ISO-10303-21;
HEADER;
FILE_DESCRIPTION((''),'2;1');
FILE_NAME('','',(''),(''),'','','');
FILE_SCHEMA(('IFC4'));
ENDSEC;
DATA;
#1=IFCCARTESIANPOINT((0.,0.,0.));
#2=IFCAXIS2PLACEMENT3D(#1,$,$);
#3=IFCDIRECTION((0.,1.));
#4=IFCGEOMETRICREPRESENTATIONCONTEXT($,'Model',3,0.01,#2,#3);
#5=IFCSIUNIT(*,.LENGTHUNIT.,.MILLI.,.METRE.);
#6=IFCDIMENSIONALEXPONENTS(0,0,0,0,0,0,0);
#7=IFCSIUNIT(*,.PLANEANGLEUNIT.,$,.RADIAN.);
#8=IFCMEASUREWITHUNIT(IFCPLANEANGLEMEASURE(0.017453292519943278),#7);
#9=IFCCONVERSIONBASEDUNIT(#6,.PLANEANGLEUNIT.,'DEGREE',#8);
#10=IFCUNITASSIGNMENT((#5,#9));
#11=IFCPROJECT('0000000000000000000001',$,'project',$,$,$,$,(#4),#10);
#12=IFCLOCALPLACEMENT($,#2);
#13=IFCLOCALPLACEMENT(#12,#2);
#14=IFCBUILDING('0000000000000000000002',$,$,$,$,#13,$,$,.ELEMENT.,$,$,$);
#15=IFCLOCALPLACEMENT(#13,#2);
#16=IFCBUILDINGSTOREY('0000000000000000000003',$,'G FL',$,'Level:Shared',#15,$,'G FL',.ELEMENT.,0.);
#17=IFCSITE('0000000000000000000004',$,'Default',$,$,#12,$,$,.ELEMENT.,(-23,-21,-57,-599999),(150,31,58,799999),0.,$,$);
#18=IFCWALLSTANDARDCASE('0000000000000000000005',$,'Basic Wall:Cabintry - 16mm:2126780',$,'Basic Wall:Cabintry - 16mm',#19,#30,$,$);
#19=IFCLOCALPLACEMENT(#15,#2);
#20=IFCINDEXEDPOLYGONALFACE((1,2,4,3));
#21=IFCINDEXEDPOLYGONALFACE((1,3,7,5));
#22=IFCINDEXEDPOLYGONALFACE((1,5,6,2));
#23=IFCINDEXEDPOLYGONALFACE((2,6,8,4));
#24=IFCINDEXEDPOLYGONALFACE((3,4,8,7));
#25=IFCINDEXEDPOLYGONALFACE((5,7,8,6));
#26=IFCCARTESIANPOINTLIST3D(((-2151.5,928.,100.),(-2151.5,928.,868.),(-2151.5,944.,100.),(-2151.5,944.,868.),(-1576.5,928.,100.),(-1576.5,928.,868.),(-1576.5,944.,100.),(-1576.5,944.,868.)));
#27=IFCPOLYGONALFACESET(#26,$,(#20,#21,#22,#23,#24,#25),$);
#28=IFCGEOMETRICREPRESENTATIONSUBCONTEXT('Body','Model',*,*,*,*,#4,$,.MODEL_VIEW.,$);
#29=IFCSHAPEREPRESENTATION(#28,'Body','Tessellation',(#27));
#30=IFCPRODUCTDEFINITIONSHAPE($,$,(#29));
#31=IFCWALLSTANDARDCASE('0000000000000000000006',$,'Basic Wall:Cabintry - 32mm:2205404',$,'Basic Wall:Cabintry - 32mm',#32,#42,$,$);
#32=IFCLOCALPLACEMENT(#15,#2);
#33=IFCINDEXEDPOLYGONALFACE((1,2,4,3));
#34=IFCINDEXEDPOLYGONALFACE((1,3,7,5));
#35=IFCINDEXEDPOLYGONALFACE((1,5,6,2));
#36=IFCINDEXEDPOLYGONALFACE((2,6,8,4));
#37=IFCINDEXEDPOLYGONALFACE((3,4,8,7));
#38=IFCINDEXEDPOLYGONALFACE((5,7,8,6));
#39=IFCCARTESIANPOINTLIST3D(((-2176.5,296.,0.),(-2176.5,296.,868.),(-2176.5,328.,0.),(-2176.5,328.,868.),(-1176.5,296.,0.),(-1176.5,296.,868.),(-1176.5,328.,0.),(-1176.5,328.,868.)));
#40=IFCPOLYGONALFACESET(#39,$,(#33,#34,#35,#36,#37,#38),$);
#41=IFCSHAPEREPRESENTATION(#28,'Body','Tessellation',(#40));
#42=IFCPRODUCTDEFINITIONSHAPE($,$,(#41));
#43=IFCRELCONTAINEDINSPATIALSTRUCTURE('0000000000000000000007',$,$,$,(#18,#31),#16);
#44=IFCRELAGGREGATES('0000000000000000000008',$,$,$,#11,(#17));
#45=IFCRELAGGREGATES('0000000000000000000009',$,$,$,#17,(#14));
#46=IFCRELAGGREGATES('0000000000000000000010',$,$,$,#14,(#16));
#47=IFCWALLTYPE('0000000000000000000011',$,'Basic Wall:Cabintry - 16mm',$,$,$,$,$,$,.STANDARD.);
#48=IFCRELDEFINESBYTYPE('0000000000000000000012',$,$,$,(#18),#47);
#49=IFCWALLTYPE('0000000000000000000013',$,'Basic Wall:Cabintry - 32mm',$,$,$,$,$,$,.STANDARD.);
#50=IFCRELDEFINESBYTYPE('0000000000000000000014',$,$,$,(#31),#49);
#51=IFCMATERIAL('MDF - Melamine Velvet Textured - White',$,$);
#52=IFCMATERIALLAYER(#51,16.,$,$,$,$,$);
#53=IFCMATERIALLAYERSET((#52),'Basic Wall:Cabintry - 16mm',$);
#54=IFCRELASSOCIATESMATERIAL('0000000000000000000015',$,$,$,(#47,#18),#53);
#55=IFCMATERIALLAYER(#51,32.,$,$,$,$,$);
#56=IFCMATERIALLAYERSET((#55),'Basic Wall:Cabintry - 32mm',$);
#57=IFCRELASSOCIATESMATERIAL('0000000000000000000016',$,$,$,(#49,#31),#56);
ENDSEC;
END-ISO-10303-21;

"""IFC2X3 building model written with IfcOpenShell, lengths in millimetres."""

from ifc_helpers import new_model, entity, si_unit, converted_unit, direction, frame, frame_2d, origin, place, context, subcontext, project, spatial, polyline, rectangle, extrude, clip, bounded_halfspace, material, layer, layer_set, layer_usage, type_object, element, save


model = new_model("IFC2X3")

# Units and contexts
model_context = context("Model", 3, precision=0.01, world=origin(), true_north=direction((0.0, 1.0)))
body_context = subcontext(model_context, "Body", "Model", "MODEL_VIEW")
ifc_project = project(units=[si_unit("LENGTHUNIT", "METRE", prefix="MILLI"), converted_unit("PLANEANGLEUNIT", "DEGREE", entity("IfcPlaneAngleMeasure", 0.017453292519943278), si_unit("PLANEANGLEUNIT", "RADIAN"), dimensions=[0, 0, 0, 0, 0, 0, 0])], contexts=[model_context])

# Site, building, storey
site_placement = place(None, origin())
site = spatial("IfcSite", under=ifc_project, at=site_placement, Name="Default", CompositionType="ELEMENT", RefLatitude=(-23, -21, -57, -599999), RefLongitude=(150, 31, 58, 799999), RefElevation=0.0)
building_placement = place(site_placement, origin())
building = spatial("IfcBuilding", under=site, at=building_placement, CompositionType="ELEMENT")
storey_placement = place(building_placement, origin())
storey = spatial("IfcBuildingStorey", under=building, at=storey_placement, Name="G FL", ObjectType="Level:Shared", LongName="G FL", CompositionType="ELEMENT", Elevation=0.0)

# Walls
ifc_material = material(Name="MDF - Melamine Velvet Textured - White")
ifc_layer_1 = layer(ifc_material, 16.0)
ifc_layer_set_1 = layer_set([ifc_layer_1], Name="Basic Wall:Cabintry - 16mm")
ifc_layer_usage_1 = layer_usage(ifc_layer_set_1, "AXIS2", "POSITIVE", -8.0)
wall_type_1 = type_object("IfcWallType", Name="Basic Wall:Cabintry - 16mm", PredefinedType="STANDARD", material=ifc_layer_set_1)
wall_1_placement = place(storey_placement, frame((-2151.5, 936.0, 100.0)))
element("IfcWallStandardCase", 1, at=wall_1_placement, inside=storey, type_object=wall_type_1, material=ifc_layer_usage_1, Name="Basic Wall:Cabintry - 16mm:2126780", ObjectType="Basic Wall:Cabintry - 16mm", context=body_context, shape_type="Clipping", body=[
    clip(extrude(rectangle(XDim=575.0, YDim=16.0, at=frame_2d((287.5, 0.0), x_axis=(-1.0, 0.0))), origin(), (0.0, 0.0, 1.0), 768.0), bounded_halfspace(frame((0.0, -8.0, 768.0), z_axis=(0.0, 0.0, -1.0), x_axis=(-1.0, 0.0, 0.0)), True, frame((0.0, -8.0, 768.0)), polyline([(0.0, 0.0), (575.0, 0.0), (575.0, 16.0), (0.0, 16.0), (0.0, 0.0)]))),
])
ifc_layer_2 = layer(ifc_material, 32.0)
ifc_layer_set_2 = layer_set([ifc_layer_2], Name="Basic Wall:Cabintry - 32mm")
ifc_layer_usage_2 = layer_usage(ifc_layer_set_2, "AXIS2", "POSITIVE", -16.0)
wall_type_2 = type_object("IfcWallType", Name="Basic Wall:Cabintry - 32mm", PredefinedType="STANDARD", material=ifc_layer_set_2)
wall_2_placement = place(storey_placement, frame((-2176.5, 312.0, 0.0)))
element("IfcWallStandardCase", 2, at=wall_2_placement, inside=storey, type_object=wall_type_2, material=ifc_layer_usage_2, Name="Basic Wall:Cabintry - 32mm:2205404", ObjectType="Basic Wall:Cabintry - 32mm", context=body_context, shape_type="Clipping", body=[
    clip(extrude(rectangle(XDim=1000.0, YDim=32.0, at=frame_2d((500.0, 0.0), x_axis=(-1.0, 0.0))), origin(), (0.0, 0.0, 1.0), 868.0), bounded_halfspace(frame((0.0, -16.0, 868.0), z_axis=(0.0, 0.0, -1.0), x_axis=(-1.0, 0.0, 0.0)), True, frame((0.0, -16.0, 868.0)), polyline([(0.0, 0.0), (1000.0, 0.0), (1000.0, 32.0), (632.0, 32.0), (600.0, 32.0), (0.0, 32.0), (0.0, 0.0)]))),
])

save(model, "model.ifc")
